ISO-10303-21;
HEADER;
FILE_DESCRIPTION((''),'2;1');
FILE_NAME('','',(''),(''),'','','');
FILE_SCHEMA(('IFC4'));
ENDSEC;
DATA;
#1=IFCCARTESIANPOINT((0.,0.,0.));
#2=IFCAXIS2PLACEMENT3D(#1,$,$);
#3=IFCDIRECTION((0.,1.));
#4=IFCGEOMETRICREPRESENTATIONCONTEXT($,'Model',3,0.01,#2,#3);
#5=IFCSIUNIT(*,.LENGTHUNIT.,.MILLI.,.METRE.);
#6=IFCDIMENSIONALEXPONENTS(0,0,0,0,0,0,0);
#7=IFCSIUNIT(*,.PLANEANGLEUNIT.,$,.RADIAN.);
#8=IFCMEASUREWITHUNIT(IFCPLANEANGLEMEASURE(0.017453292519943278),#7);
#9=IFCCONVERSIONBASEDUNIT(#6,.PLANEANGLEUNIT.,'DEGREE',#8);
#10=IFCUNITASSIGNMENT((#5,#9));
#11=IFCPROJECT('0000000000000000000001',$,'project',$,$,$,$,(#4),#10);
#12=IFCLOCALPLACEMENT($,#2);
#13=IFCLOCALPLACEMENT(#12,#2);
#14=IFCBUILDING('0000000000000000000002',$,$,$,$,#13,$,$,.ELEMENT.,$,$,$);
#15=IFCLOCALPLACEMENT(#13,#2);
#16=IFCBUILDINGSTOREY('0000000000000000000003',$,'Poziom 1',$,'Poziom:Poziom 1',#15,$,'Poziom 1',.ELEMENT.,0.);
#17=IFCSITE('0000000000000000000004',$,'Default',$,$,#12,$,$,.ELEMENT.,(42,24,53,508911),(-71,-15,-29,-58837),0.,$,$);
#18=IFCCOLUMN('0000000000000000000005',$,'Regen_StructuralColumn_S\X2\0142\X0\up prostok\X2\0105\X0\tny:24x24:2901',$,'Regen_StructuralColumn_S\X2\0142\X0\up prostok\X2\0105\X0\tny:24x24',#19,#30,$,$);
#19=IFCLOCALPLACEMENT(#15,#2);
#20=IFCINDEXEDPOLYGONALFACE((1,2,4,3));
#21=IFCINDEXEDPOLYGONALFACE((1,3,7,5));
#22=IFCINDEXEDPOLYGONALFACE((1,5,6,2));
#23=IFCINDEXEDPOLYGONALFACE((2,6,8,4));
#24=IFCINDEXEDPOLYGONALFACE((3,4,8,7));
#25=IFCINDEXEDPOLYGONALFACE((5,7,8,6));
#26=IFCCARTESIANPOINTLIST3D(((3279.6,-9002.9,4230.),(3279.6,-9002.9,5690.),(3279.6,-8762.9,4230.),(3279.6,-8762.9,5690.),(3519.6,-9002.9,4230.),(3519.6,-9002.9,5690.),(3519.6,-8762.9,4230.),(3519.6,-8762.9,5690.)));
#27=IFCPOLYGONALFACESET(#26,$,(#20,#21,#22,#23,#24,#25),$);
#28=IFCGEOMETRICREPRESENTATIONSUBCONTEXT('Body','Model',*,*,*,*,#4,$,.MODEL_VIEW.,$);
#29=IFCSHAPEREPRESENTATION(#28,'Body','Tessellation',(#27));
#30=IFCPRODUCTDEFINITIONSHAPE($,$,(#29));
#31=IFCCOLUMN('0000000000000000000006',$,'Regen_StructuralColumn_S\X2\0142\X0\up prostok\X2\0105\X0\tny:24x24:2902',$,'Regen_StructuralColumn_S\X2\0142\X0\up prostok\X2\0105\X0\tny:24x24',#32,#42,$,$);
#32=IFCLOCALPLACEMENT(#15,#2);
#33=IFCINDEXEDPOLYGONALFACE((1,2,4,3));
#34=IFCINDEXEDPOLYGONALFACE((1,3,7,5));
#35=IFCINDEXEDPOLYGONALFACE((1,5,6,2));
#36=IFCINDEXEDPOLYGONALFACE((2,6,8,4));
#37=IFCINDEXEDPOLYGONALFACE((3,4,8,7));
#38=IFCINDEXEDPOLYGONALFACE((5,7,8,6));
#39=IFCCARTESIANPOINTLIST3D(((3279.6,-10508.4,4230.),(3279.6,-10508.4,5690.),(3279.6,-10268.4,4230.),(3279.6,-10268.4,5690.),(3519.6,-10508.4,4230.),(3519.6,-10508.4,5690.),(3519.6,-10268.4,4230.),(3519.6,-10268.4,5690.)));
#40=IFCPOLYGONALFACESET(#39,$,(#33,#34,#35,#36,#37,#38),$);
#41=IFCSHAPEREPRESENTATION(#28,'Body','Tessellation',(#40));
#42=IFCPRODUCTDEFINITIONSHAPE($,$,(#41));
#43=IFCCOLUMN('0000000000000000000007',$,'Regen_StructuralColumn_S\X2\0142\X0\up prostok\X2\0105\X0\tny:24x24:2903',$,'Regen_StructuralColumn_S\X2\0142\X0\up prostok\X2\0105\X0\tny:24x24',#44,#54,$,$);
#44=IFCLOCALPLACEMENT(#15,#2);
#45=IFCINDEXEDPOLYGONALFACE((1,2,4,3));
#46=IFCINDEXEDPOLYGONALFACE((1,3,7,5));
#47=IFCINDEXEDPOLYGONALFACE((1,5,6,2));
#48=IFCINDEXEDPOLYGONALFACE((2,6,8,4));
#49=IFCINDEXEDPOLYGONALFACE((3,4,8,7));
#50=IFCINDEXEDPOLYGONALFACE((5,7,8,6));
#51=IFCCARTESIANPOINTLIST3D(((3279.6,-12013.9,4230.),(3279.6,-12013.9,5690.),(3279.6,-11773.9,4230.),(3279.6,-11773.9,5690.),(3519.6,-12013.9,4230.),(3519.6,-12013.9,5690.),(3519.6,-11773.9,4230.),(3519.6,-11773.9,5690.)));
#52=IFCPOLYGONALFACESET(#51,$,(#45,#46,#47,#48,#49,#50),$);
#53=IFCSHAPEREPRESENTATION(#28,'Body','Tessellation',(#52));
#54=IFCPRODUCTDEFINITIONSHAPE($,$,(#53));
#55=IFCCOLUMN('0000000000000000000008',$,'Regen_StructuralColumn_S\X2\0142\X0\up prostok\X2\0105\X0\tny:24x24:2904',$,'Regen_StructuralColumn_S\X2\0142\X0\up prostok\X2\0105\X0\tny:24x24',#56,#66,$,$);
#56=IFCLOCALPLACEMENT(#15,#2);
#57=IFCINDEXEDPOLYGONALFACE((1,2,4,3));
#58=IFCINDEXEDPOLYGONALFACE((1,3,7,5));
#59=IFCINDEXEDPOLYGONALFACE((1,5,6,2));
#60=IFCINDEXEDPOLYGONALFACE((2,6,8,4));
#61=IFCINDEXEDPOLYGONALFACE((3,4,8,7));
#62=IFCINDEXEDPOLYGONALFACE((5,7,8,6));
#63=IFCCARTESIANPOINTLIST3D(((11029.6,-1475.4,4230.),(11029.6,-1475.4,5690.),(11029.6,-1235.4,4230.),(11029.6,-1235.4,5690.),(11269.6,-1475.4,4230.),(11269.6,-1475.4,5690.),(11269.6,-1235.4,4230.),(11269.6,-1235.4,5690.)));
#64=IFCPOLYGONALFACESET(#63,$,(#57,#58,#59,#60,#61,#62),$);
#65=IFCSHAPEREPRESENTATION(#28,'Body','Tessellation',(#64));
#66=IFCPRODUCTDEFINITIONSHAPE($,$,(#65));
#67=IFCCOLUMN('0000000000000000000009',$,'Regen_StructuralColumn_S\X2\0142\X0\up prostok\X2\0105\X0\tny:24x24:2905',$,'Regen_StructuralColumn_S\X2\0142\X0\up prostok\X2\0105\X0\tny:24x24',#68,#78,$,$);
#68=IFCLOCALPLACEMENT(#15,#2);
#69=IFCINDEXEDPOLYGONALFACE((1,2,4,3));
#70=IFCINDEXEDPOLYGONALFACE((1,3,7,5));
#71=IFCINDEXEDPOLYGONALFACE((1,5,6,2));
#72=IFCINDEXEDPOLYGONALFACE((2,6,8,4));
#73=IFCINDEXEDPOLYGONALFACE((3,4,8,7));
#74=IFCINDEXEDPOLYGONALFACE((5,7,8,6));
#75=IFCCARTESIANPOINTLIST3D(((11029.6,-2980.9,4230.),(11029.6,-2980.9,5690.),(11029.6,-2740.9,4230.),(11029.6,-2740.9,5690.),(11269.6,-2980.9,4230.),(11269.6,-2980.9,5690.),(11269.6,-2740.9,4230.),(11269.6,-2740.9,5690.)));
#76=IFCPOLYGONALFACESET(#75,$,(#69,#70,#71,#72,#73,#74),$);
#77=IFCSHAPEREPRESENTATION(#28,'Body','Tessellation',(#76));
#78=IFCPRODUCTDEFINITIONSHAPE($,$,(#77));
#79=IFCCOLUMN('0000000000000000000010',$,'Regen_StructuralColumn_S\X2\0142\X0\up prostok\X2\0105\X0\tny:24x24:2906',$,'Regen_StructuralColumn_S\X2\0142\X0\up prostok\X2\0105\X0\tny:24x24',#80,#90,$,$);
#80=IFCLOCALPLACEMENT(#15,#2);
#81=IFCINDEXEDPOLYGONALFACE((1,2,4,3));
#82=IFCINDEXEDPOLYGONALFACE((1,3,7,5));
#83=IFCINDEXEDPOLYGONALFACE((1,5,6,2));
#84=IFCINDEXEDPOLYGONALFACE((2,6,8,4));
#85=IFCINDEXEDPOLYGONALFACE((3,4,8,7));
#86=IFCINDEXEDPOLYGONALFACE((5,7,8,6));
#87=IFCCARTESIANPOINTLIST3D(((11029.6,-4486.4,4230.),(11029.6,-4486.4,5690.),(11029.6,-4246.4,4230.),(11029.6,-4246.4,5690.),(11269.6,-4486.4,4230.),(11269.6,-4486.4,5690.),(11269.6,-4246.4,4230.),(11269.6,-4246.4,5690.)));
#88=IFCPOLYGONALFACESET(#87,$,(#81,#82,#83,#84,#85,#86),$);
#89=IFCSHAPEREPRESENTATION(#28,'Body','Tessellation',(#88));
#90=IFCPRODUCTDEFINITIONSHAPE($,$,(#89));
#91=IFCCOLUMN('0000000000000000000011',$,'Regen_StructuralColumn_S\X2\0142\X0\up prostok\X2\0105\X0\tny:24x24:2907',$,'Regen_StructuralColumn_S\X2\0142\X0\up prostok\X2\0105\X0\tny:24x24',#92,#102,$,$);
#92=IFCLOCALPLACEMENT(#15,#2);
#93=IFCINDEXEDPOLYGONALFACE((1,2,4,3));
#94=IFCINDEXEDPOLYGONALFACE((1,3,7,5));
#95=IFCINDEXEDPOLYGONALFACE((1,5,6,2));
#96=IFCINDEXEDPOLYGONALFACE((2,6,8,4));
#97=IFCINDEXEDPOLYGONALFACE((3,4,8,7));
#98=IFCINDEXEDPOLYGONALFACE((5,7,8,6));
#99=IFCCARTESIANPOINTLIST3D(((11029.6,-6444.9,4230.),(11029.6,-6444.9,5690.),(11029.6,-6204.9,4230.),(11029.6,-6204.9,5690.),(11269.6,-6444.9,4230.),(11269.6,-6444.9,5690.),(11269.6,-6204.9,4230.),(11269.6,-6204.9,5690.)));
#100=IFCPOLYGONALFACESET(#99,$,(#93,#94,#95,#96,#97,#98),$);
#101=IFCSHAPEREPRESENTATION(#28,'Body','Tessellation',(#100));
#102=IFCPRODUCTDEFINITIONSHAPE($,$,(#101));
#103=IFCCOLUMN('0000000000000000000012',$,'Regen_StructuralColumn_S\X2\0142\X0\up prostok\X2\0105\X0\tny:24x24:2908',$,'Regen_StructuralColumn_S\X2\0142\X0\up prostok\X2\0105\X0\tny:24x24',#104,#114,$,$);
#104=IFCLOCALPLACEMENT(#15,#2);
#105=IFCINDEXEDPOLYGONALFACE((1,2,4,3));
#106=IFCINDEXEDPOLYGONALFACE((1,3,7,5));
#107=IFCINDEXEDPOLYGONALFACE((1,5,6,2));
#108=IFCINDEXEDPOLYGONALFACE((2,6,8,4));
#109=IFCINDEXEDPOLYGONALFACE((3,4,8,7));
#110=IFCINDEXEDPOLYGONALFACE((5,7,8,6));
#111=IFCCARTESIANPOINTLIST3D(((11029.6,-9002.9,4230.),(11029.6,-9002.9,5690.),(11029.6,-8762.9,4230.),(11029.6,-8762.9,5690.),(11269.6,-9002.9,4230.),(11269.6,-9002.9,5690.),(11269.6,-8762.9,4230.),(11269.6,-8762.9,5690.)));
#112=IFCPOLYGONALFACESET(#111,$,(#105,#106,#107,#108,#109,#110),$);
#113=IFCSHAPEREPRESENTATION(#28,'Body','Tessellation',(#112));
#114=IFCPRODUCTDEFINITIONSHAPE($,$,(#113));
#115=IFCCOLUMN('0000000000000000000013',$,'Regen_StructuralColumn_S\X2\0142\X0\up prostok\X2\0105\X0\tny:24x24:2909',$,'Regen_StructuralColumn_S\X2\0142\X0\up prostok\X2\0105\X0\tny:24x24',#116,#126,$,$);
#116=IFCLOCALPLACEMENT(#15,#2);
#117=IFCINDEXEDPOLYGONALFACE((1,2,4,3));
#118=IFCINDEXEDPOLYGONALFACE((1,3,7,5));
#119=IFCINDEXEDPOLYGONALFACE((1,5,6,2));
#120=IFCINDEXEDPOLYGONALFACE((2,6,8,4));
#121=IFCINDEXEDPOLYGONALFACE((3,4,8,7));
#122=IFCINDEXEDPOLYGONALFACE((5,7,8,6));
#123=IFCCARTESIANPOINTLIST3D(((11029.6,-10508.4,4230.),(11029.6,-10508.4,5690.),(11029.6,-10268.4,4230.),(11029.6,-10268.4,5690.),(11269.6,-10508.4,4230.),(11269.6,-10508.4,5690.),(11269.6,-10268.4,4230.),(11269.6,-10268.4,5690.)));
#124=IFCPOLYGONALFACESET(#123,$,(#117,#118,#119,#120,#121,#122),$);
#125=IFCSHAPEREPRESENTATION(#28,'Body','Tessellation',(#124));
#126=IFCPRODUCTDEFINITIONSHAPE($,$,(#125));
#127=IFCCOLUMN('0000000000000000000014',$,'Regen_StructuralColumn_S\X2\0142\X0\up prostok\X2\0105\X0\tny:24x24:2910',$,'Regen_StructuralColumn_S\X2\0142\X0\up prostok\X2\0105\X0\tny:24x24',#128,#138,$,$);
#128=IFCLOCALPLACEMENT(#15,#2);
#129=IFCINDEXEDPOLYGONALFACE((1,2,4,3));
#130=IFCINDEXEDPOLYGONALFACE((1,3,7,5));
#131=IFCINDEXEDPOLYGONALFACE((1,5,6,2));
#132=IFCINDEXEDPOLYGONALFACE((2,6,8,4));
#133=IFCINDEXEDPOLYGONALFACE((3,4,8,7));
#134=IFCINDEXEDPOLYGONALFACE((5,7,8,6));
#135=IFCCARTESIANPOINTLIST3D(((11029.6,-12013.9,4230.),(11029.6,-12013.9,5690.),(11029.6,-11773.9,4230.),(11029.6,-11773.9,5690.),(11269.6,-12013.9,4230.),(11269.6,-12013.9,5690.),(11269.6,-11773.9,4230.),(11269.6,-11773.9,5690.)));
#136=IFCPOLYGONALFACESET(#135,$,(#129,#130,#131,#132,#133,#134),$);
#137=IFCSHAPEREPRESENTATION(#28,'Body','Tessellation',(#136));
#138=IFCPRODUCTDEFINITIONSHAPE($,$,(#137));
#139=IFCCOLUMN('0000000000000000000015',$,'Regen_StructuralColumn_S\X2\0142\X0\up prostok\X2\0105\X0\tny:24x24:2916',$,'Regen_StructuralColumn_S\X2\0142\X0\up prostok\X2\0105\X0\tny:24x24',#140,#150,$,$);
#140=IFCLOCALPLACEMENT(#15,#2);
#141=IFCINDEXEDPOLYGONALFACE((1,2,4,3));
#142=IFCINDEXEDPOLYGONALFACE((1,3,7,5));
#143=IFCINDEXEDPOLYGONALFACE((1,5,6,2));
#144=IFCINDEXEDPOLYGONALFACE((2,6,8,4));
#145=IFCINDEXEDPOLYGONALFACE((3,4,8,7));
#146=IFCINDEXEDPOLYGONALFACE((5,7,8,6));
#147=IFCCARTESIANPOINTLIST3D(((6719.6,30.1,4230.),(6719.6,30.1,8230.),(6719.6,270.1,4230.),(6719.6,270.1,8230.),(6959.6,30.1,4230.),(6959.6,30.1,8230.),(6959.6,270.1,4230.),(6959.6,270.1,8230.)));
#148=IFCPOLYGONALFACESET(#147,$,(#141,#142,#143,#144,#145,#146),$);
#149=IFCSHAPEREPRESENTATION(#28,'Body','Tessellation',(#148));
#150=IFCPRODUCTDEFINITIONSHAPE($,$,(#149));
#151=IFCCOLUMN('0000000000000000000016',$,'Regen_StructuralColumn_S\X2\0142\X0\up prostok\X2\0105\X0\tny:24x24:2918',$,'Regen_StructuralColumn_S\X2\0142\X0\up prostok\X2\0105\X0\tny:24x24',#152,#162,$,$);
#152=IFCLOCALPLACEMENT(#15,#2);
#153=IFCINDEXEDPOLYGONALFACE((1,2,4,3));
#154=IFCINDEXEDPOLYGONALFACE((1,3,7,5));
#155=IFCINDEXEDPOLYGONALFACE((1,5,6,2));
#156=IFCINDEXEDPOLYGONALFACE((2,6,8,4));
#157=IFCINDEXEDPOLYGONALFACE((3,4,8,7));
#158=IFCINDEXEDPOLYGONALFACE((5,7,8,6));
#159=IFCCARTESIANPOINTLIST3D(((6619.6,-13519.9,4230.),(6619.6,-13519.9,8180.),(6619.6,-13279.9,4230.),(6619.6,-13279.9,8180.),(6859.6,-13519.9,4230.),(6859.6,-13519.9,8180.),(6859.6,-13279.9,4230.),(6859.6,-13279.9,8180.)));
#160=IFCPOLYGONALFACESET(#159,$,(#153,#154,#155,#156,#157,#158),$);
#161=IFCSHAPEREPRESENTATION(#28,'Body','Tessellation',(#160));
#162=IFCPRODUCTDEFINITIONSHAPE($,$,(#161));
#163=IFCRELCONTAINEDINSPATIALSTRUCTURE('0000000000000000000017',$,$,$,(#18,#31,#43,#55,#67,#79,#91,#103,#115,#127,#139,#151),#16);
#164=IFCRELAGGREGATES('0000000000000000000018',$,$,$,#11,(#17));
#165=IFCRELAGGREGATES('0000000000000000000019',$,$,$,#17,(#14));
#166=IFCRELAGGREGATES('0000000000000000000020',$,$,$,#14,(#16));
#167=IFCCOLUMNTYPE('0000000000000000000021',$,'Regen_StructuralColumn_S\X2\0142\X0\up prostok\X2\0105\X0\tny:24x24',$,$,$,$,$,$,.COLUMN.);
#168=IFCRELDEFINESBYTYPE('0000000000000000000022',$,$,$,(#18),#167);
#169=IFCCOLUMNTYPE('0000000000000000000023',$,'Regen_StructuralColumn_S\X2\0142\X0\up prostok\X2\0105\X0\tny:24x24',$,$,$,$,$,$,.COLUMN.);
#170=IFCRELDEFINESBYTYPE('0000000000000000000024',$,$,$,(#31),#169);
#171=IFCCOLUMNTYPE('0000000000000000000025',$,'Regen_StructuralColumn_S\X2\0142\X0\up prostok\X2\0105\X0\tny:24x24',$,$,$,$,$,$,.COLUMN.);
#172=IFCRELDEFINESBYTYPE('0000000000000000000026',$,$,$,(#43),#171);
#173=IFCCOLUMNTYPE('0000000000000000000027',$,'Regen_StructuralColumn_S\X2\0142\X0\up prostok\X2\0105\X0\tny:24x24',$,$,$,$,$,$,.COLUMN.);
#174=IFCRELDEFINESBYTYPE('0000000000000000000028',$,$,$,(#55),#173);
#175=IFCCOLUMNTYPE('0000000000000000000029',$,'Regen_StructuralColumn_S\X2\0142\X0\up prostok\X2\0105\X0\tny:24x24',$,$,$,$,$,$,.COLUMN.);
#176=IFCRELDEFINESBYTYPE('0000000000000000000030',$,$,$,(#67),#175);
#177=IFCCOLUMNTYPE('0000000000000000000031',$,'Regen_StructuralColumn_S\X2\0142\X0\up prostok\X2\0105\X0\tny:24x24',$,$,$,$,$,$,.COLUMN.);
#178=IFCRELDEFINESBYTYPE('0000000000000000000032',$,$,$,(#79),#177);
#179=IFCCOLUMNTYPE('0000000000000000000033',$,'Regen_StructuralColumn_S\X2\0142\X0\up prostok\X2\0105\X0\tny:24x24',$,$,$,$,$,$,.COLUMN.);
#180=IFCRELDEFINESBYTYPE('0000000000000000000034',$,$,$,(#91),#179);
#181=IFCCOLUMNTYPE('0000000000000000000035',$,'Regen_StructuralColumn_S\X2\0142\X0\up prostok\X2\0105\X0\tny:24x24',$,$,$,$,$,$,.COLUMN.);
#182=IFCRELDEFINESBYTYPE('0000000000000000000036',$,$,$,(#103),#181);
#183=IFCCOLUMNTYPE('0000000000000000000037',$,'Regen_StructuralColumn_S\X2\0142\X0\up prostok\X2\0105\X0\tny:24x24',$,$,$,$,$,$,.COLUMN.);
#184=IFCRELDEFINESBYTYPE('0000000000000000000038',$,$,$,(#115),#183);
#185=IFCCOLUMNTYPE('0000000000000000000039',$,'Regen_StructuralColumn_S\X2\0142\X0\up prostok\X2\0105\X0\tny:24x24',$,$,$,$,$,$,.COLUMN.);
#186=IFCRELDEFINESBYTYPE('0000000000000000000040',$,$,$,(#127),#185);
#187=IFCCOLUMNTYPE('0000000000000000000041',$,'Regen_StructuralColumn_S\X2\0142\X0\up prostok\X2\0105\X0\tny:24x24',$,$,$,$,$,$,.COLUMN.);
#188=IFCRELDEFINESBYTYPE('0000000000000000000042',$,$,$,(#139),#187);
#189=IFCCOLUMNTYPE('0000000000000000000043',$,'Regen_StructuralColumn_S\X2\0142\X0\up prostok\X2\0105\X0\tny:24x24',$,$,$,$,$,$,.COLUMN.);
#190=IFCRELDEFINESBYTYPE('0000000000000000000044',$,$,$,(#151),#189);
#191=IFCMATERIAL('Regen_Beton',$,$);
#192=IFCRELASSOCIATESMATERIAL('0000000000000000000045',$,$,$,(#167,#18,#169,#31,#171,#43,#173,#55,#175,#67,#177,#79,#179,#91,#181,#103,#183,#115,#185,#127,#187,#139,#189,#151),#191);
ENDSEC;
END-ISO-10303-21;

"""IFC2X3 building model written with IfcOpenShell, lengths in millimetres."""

from ifc_helpers import new_model, entity, si_unit, converted_unit, direction, frame, frame_2d, origin, origin_2d_with_axis, place, context, subcontext, project, spatial, rectangle, extrude, source, transform, mapped, material, type_object, type_shapes, element, save


model = new_model("IFC2X3")

# Units and contexts
model_context = context("Model", 3, precision=0.01, world=origin(), true_north=direction((0.0, 1.0)))
body_context = subcontext(model_context, "Body", "Model", "MODEL_VIEW")
ifc_project = project(units=[si_unit("LENGTHUNIT", "METRE", prefix="MILLI"), converted_unit("PLANEANGLEUNIT", "DEGREE", entity("IfcPlaneAngleMeasure", 0.017453292519943278), si_unit("PLANEANGLEUNIT", "RADIAN"), dimensions=[0, 0, 0, 0, 0, 0, 0])], contexts=[model_context])

# Site, building, storey
site_placement = place(None, origin())
site = spatial("IfcSite", under=ifc_project, at=site_placement, Name="Default", CompositionType="ELEMENT", RefLatitude=(42, 24, 53, 508911), RefLongitude=(-71, -15, -29, -58837), RefElevation=0.0)
building_placement = place(site_placement, origin())
building = spatial("IfcBuilding", under=site, at=building_placement, CompositionType="ELEMENT")
storey_placement = place(building_placement, origin())
storey = spatial("IfcBuildingStorey", under=building, at=storey_placement, Name="Poziom 1", ObjectType="Poziom:Poziom 1", LongName="Poziom 1", CompositionType="ELEMENT", Elevation=0.0)

# Columns
ifc_material_1 = material(Name="Regen_Beton")
column_type_1 = type_object("IfcColumnType", Name="Regen_StructuralColumn_Słup prostokątny:24x24", PredefinedType="COLUMN", material=ifc_material_1)
shared_shape_1 = source(origin(), body_context, "Body", "SweptSolid", [
    extrude(rectangle(XDim=240.0, YDim=240.0, at=frame_2d((0.0, 0.0), x_axis=(1.0, 0.0))), frame((3399.6, -8882.9, 4230.0), z_axis=(0.0, 0.0, 1.0), x_axis=(-1.0, 0.0, 0.0)), (0.0, 0.0, 1.0), 1460.0),
])
type_shapes(column_type_1, [shared_shape_1])
column_1_placement = place(storey_placement, origin())
element("IfcColumn", 1, at=column_1_placement, inside=storey, type_object=column_type_1, material=ifc_material_1, Name="Regen_StructuralColumn_Słup prostokątny:24x24:2901", ObjectType="Regen_StructuralColumn_Słup prostokątny:24x24", context=body_context, shape_type="MappedRepresentation", body=[
    mapped(shared_shape_1, transform((0.0, 0.0, 0.0), scale=1.0)),
])
column_type_2 = type_object("IfcColumnType", Name="Regen_StructuralColumn_Słup prostokątny:24x24", PredefinedType="COLUMN", material=ifc_material_1)
shared_shape_2 = source(origin(), body_context, "Body", "SweptSolid", [
    extrude(rectangle(XDim=240.0, YDim=240.0, at=frame_2d((0.0, 0.0), x_axis=(1.0, 0.0))), frame((3399.6, -10388.4, 4230.0), z_axis=(0.0, 0.0, 1.0), x_axis=(-1.0, 0.0, 0.0)), (0.0, 0.0, 1.0), 1460.0),
])
type_shapes(column_type_2, [shared_shape_2])
column_2_placement = place(storey_placement, origin())
element("IfcColumn", 2, at=column_2_placement, inside=storey, type_object=column_type_2, material=ifc_material_1, Name="Regen_StructuralColumn_Słup prostokątny:24x24:2902", ObjectType="Regen_StructuralColumn_Słup prostokątny:24x24", context=body_context, shape_type="MappedRepresentation", body=[
    mapped(shared_shape_2, transform((0.0, 0.0, 0.0), scale=1.0)),
])
column_type_3 = type_object("IfcColumnType", Name="Regen_StructuralColumn_Słup prostokątny:24x24", PredefinedType="COLUMN", material=ifc_material_1)
shared_shape_3 = source(origin(), body_context, "Body", "SweptSolid", [
    extrude(rectangle(XDim=240.0, YDim=240.0, at=frame_2d((0.0, 0.0), x_axis=(1.0, 0.0))), frame((3399.6, -11893.9, 4230.0), z_axis=(0.0, 0.0, 1.0), x_axis=(-1.0, 0.0, 0.0)), (0.0, 0.0, 1.0), 1460.0),
])
type_shapes(column_type_3, [shared_shape_3])
column_3_placement = place(storey_placement, origin())
element("IfcColumn", 3, at=column_3_placement, inside=storey, type_object=column_type_3, material=ifc_material_1, Name="Regen_StructuralColumn_Słup prostokątny:24x24:2903", ObjectType="Regen_StructuralColumn_Słup prostokątny:24x24", context=body_context, shape_type="MappedRepresentation", body=[
    mapped(shared_shape_3, transform((0.0, 0.0, 0.0), scale=1.0)),
])
column_type_4 = type_object("IfcColumnType", Name="Regen_StructuralColumn_Słup prostokątny:24x24", PredefinedType="COLUMN", material=ifc_material_1)
shared_shape_4 = source(origin(), body_context, "Body", "SweptSolid", [
    extrude(rectangle(XDim=240.0, YDim=240.0, at=frame_2d((0.0, 0.0), x_axis=(1.0, 0.0))), frame((11149.6, -1355.4, 4230.0), z_axis=(0.0, 0.0, 1.0), x_axis=(-1.0, 0.0, 0.0)), (0.0, 0.0, 1.0), 1460.0),
])
type_shapes(column_type_4, [shared_shape_4])
column_4_placement = place(storey_placement, origin())
element("IfcColumn", 4, at=column_4_placement, inside=storey, type_object=column_type_4, material=ifc_material_1, Name="Regen_StructuralColumn_Słup prostokątny:24x24:2904", ObjectType="Regen_StructuralColumn_Słup prostokątny:24x24", context=body_context, shape_type="MappedRepresentation", body=[
    mapped(shared_shape_4, transform((0.0, 0.0, 0.0), scale=1.0)),
])
column_type_5 = type_object("IfcColumnType", Name="Regen_StructuralColumn_Słup prostokątny:24x24", PredefinedType="COLUMN", material=ifc_material_1)
shared_shape_5 = source(origin(), body_context, "Body", "SweptSolid", [
    extrude(rectangle(XDim=240.0, YDim=240.0, at=frame_2d((0.0, 0.0), x_axis=(1.0, 0.0))), frame((11149.6, -2860.9, 4230.0), z_axis=(0.0, 0.0, 1.0), x_axis=(-1.0, 0.0, 0.0)), (0.0, 0.0, 1.0), 1460.0),
])
type_shapes(column_type_5, [shared_shape_5])
column_5_placement = place(storey_placement, origin())
element("IfcColumn", 5, at=column_5_placement, inside=storey, type_object=column_type_5, material=ifc_material_1, Name="Regen_StructuralColumn_Słup prostokątny:24x24:2905", ObjectType="Regen_StructuralColumn_Słup prostokątny:24x24", context=body_context, shape_type="MappedRepresentation", body=[
    mapped(shared_shape_5, transform((0.0, 0.0, 0.0), scale=1.0)),
])
column_type_6 = type_object("IfcColumnType", Name="Regen_StructuralColumn_Słup prostokątny:24x24", PredefinedType="COLUMN", material=ifc_material_1)
shared_shape_6 = source(origin(), body_context, "Body", "SweptSolid", [
    extrude(rectangle(XDim=240.0, YDim=240.0, at=frame_2d((0.0, 0.0), x_axis=(1.0, 0.0))), frame((11149.6, -4366.4, 4230.0), z_axis=(0.0, 0.0, 1.0), x_axis=(-1.0, 0.0, 0.0)), (0.0, 0.0, 1.0), 1460.0),
])
type_shapes(column_type_6, [shared_shape_6])
column_6_placement = place(storey_placement, origin())
element("IfcColumn", 6, at=column_6_placement, inside=storey, type_object=column_type_6, material=ifc_material_1, Name="Regen_StructuralColumn_Słup prostokątny:24x24:2906", ObjectType="Regen_StructuralColumn_Słup prostokątny:24x24", context=body_context, shape_type="MappedRepresentation", body=[
    mapped(shared_shape_6, transform((0.0, 0.0, 0.0), scale=1.0)),
])
column_type_7 = type_object("IfcColumnType", Name="Regen_StructuralColumn_Słup prostokątny:24x24", PredefinedType="COLUMN", material=ifc_material_1)
shared_shape_7 = source(origin(), body_context, "Body", "SweptSolid", [
    extrude(rectangle(XDim=240.0, YDim=240.0, at=frame_2d((0.0, 0.0), x_axis=(1.0, 0.0))), frame((11149.6, -6324.9, 4230.0), z_axis=(0.0, 0.0, 1.0), x_axis=(-1.0, 0.0, 0.0)), (0.0, 0.0, 1.0), 1460.0),
])
type_shapes(column_type_7, [shared_shape_7])
column_7_placement = place(storey_placement, origin())
element("IfcColumn", 7, at=column_7_placement, inside=storey, type_object=column_type_7, material=ifc_material_1, Name="Regen_StructuralColumn_Słup prostokątny:24x24:2907", ObjectType="Regen_StructuralColumn_Słup prostokątny:24x24", context=body_context, shape_type="MappedRepresentation", body=[
    mapped(shared_shape_7, transform((0.0, 0.0, 0.0), scale=1.0)),
])
column_type_8 = type_object("IfcColumnType", Name="Regen_StructuralColumn_Słup prostokątny:24x24", PredefinedType="COLUMN", material=ifc_material_1)
shared_shape_8 = source(origin(), body_context, "Body", "SweptSolid", [
    extrude(rectangle(XDim=240.0, YDim=240.0, at=frame_2d((0.0, 0.0), x_axis=(1.0, 0.0))), frame((11149.6, -8882.9, 4230.0), z_axis=(0.0, 0.0, 1.0), x_axis=(-1.0, 0.0, 0.0)), (0.0, 0.0, 1.0), 1460.0),
])
type_shapes(column_type_8, [shared_shape_8])
column_8_placement = place(storey_placement, origin())
element("IfcColumn", 8, at=column_8_placement, inside=storey, type_object=column_type_8, material=ifc_material_1, Name="Regen_StructuralColumn_Słup prostokątny:24x24:2908", ObjectType="Regen_StructuralColumn_Słup prostokątny:24x24", context=body_context, shape_type="MappedRepresentation", body=[
    mapped(shared_shape_8, transform((0.0, 0.0, 0.0), scale=1.0)),
])
column_type_9 = type_object("IfcColumnType", Name="Regen_StructuralColumn_Słup prostokątny:24x24", PredefinedType="COLUMN", material=ifc_material_1)
shared_shape_9 = source(origin(), body_context, "Body", "SweptSolid", [
    extrude(rectangle(XDim=240.0, YDim=240.0, at=frame_2d((0.0, 0.0), x_axis=(1.0, 0.0))), frame((11149.6, -10388.4, 4230.0), z_axis=(0.0, 0.0, 1.0), x_axis=(-1.0, 0.0, 0.0)), (0.0, 0.0, 1.0), 1460.0),
])
type_shapes(column_type_9, [shared_shape_9])
column_9_placement = place(storey_placement, origin())
element("IfcColumn", 9, at=column_9_placement, inside=storey, type_object=column_type_9, material=ifc_material_1, Name="Regen_StructuralColumn_Słup prostokątny:24x24:2909", ObjectType="Regen_StructuralColumn_Słup prostokątny:24x24", context=body_context, shape_type="MappedRepresentation", body=[
    mapped(shared_shape_9, transform((0.0, 0.0, 0.0), scale=1.0)),
])
column_type_10 = type_object("IfcColumnType", Name="Regen_StructuralColumn_Słup prostokątny:24x24", PredefinedType="COLUMN", material=ifc_material_1)
shared_shape_10 = source(origin(), body_context, "Body", "SweptSolid", [
    extrude(rectangle(XDim=240.0, YDim=240.0, at=frame_2d((0.0, 0.0), x_axis=(1.0, 0.0))), frame((11149.6, -11893.9, 4230.0), z_axis=(0.0, 0.0, 1.0), x_axis=(-1.0, 0.0, 0.0)), (0.0, 0.0, 1.0), 1460.0),
])
type_shapes(column_type_10, [shared_shape_10])
column_10_placement = place(storey_placement, origin())
element("IfcColumn", 10, at=column_10_placement, inside=storey, type_object=column_type_10, material=ifc_material_1, Name="Regen_StructuralColumn_Słup prostokątny:24x24:2910", ObjectType="Regen_StructuralColumn_Słup prostokątny:24x24", context=body_context, shape_type="MappedRepresentation", body=[
    mapped(shared_shape_10, transform((0.0, 0.0, 0.0), scale=1.0)),
])
column_type_11 = type_object("IfcColumnType", Name="Regen_StructuralColumn_Słup prostokątny:24x24", PredefinedType="COLUMN", material=ifc_material_1)
shared_shape_11 = source(origin(), body_context, "Body", "SweptSolid", [
    extrude(rectangle(XDim=240.0, YDim=240.0, at=origin_2d_with_axis()), frame((6839.6, 150.1, 4230.0), z_axis=(0.0, 0.0, 1.0), x_axis=(-1.0, 0.0, 0.0)), (0.0, 0.0, 1.0), 4000.0),
])
type_shapes(column_type_11, [shared_shape_11])
column_11_placement = place(storey_placement, origin())
element("IfcColumn", 11, at=column_11_placement, inside=storey, type_object=column_type_11, material=ifc_material_1, Name="Regen_StructuralColumn_Słup prostokątny:24x24:2916", ObjectType="Regen_StructuralColumn_Słup prostokątny:24x24", context=body_context, shape_type="MappedRepresentation", body=[
    mapped(shared_shape_11, transform((0.0, 0.0, 0.0), scale=1.0)),
])
column_type_12 = type_object("IfcColumnType", Name="Regen_StructuralColumn_Słup prostokątny:24x24", PredefinedType="COLUMN", material=ifc_material_1)
shared_shape_12 = source(origin(), body_context, "Body", "SweptSolid", [
    extrude(rectangle(XDim=240.0, YDim=240.0, at=frame_2d((0.0, 0.0), x_axis=(1.0, 0.0))), frame((6739.6, -13399.9, 4230.0), z_axis=(0.0, 0.0, 1.0), x_axis=(-1.0, 0.0, 0.0)), (0.0, 0.0, 1.0), 3950.0),
])
type_shapes(column_type_12, [shared_shape_12])
column_12_placement = place(storey_placement, origin())
element("IfcColumn", 12, at=column_12_placement, inside=storey, type_object=column_type_12, material=ifc_material_1, Name="Regen_StructuralColumn_Słup prostokątny:24x24:2918", ObjectType="Regen_StructuralColumn_Słup prostokątny:24x24", context=body_context, shape_type="MappedRepresentation", body=[
    mapped(shared_shape_12, transform((0.0, 0.0, 0.0), scale=1.0)),
])

save(model, "model.ifc")
